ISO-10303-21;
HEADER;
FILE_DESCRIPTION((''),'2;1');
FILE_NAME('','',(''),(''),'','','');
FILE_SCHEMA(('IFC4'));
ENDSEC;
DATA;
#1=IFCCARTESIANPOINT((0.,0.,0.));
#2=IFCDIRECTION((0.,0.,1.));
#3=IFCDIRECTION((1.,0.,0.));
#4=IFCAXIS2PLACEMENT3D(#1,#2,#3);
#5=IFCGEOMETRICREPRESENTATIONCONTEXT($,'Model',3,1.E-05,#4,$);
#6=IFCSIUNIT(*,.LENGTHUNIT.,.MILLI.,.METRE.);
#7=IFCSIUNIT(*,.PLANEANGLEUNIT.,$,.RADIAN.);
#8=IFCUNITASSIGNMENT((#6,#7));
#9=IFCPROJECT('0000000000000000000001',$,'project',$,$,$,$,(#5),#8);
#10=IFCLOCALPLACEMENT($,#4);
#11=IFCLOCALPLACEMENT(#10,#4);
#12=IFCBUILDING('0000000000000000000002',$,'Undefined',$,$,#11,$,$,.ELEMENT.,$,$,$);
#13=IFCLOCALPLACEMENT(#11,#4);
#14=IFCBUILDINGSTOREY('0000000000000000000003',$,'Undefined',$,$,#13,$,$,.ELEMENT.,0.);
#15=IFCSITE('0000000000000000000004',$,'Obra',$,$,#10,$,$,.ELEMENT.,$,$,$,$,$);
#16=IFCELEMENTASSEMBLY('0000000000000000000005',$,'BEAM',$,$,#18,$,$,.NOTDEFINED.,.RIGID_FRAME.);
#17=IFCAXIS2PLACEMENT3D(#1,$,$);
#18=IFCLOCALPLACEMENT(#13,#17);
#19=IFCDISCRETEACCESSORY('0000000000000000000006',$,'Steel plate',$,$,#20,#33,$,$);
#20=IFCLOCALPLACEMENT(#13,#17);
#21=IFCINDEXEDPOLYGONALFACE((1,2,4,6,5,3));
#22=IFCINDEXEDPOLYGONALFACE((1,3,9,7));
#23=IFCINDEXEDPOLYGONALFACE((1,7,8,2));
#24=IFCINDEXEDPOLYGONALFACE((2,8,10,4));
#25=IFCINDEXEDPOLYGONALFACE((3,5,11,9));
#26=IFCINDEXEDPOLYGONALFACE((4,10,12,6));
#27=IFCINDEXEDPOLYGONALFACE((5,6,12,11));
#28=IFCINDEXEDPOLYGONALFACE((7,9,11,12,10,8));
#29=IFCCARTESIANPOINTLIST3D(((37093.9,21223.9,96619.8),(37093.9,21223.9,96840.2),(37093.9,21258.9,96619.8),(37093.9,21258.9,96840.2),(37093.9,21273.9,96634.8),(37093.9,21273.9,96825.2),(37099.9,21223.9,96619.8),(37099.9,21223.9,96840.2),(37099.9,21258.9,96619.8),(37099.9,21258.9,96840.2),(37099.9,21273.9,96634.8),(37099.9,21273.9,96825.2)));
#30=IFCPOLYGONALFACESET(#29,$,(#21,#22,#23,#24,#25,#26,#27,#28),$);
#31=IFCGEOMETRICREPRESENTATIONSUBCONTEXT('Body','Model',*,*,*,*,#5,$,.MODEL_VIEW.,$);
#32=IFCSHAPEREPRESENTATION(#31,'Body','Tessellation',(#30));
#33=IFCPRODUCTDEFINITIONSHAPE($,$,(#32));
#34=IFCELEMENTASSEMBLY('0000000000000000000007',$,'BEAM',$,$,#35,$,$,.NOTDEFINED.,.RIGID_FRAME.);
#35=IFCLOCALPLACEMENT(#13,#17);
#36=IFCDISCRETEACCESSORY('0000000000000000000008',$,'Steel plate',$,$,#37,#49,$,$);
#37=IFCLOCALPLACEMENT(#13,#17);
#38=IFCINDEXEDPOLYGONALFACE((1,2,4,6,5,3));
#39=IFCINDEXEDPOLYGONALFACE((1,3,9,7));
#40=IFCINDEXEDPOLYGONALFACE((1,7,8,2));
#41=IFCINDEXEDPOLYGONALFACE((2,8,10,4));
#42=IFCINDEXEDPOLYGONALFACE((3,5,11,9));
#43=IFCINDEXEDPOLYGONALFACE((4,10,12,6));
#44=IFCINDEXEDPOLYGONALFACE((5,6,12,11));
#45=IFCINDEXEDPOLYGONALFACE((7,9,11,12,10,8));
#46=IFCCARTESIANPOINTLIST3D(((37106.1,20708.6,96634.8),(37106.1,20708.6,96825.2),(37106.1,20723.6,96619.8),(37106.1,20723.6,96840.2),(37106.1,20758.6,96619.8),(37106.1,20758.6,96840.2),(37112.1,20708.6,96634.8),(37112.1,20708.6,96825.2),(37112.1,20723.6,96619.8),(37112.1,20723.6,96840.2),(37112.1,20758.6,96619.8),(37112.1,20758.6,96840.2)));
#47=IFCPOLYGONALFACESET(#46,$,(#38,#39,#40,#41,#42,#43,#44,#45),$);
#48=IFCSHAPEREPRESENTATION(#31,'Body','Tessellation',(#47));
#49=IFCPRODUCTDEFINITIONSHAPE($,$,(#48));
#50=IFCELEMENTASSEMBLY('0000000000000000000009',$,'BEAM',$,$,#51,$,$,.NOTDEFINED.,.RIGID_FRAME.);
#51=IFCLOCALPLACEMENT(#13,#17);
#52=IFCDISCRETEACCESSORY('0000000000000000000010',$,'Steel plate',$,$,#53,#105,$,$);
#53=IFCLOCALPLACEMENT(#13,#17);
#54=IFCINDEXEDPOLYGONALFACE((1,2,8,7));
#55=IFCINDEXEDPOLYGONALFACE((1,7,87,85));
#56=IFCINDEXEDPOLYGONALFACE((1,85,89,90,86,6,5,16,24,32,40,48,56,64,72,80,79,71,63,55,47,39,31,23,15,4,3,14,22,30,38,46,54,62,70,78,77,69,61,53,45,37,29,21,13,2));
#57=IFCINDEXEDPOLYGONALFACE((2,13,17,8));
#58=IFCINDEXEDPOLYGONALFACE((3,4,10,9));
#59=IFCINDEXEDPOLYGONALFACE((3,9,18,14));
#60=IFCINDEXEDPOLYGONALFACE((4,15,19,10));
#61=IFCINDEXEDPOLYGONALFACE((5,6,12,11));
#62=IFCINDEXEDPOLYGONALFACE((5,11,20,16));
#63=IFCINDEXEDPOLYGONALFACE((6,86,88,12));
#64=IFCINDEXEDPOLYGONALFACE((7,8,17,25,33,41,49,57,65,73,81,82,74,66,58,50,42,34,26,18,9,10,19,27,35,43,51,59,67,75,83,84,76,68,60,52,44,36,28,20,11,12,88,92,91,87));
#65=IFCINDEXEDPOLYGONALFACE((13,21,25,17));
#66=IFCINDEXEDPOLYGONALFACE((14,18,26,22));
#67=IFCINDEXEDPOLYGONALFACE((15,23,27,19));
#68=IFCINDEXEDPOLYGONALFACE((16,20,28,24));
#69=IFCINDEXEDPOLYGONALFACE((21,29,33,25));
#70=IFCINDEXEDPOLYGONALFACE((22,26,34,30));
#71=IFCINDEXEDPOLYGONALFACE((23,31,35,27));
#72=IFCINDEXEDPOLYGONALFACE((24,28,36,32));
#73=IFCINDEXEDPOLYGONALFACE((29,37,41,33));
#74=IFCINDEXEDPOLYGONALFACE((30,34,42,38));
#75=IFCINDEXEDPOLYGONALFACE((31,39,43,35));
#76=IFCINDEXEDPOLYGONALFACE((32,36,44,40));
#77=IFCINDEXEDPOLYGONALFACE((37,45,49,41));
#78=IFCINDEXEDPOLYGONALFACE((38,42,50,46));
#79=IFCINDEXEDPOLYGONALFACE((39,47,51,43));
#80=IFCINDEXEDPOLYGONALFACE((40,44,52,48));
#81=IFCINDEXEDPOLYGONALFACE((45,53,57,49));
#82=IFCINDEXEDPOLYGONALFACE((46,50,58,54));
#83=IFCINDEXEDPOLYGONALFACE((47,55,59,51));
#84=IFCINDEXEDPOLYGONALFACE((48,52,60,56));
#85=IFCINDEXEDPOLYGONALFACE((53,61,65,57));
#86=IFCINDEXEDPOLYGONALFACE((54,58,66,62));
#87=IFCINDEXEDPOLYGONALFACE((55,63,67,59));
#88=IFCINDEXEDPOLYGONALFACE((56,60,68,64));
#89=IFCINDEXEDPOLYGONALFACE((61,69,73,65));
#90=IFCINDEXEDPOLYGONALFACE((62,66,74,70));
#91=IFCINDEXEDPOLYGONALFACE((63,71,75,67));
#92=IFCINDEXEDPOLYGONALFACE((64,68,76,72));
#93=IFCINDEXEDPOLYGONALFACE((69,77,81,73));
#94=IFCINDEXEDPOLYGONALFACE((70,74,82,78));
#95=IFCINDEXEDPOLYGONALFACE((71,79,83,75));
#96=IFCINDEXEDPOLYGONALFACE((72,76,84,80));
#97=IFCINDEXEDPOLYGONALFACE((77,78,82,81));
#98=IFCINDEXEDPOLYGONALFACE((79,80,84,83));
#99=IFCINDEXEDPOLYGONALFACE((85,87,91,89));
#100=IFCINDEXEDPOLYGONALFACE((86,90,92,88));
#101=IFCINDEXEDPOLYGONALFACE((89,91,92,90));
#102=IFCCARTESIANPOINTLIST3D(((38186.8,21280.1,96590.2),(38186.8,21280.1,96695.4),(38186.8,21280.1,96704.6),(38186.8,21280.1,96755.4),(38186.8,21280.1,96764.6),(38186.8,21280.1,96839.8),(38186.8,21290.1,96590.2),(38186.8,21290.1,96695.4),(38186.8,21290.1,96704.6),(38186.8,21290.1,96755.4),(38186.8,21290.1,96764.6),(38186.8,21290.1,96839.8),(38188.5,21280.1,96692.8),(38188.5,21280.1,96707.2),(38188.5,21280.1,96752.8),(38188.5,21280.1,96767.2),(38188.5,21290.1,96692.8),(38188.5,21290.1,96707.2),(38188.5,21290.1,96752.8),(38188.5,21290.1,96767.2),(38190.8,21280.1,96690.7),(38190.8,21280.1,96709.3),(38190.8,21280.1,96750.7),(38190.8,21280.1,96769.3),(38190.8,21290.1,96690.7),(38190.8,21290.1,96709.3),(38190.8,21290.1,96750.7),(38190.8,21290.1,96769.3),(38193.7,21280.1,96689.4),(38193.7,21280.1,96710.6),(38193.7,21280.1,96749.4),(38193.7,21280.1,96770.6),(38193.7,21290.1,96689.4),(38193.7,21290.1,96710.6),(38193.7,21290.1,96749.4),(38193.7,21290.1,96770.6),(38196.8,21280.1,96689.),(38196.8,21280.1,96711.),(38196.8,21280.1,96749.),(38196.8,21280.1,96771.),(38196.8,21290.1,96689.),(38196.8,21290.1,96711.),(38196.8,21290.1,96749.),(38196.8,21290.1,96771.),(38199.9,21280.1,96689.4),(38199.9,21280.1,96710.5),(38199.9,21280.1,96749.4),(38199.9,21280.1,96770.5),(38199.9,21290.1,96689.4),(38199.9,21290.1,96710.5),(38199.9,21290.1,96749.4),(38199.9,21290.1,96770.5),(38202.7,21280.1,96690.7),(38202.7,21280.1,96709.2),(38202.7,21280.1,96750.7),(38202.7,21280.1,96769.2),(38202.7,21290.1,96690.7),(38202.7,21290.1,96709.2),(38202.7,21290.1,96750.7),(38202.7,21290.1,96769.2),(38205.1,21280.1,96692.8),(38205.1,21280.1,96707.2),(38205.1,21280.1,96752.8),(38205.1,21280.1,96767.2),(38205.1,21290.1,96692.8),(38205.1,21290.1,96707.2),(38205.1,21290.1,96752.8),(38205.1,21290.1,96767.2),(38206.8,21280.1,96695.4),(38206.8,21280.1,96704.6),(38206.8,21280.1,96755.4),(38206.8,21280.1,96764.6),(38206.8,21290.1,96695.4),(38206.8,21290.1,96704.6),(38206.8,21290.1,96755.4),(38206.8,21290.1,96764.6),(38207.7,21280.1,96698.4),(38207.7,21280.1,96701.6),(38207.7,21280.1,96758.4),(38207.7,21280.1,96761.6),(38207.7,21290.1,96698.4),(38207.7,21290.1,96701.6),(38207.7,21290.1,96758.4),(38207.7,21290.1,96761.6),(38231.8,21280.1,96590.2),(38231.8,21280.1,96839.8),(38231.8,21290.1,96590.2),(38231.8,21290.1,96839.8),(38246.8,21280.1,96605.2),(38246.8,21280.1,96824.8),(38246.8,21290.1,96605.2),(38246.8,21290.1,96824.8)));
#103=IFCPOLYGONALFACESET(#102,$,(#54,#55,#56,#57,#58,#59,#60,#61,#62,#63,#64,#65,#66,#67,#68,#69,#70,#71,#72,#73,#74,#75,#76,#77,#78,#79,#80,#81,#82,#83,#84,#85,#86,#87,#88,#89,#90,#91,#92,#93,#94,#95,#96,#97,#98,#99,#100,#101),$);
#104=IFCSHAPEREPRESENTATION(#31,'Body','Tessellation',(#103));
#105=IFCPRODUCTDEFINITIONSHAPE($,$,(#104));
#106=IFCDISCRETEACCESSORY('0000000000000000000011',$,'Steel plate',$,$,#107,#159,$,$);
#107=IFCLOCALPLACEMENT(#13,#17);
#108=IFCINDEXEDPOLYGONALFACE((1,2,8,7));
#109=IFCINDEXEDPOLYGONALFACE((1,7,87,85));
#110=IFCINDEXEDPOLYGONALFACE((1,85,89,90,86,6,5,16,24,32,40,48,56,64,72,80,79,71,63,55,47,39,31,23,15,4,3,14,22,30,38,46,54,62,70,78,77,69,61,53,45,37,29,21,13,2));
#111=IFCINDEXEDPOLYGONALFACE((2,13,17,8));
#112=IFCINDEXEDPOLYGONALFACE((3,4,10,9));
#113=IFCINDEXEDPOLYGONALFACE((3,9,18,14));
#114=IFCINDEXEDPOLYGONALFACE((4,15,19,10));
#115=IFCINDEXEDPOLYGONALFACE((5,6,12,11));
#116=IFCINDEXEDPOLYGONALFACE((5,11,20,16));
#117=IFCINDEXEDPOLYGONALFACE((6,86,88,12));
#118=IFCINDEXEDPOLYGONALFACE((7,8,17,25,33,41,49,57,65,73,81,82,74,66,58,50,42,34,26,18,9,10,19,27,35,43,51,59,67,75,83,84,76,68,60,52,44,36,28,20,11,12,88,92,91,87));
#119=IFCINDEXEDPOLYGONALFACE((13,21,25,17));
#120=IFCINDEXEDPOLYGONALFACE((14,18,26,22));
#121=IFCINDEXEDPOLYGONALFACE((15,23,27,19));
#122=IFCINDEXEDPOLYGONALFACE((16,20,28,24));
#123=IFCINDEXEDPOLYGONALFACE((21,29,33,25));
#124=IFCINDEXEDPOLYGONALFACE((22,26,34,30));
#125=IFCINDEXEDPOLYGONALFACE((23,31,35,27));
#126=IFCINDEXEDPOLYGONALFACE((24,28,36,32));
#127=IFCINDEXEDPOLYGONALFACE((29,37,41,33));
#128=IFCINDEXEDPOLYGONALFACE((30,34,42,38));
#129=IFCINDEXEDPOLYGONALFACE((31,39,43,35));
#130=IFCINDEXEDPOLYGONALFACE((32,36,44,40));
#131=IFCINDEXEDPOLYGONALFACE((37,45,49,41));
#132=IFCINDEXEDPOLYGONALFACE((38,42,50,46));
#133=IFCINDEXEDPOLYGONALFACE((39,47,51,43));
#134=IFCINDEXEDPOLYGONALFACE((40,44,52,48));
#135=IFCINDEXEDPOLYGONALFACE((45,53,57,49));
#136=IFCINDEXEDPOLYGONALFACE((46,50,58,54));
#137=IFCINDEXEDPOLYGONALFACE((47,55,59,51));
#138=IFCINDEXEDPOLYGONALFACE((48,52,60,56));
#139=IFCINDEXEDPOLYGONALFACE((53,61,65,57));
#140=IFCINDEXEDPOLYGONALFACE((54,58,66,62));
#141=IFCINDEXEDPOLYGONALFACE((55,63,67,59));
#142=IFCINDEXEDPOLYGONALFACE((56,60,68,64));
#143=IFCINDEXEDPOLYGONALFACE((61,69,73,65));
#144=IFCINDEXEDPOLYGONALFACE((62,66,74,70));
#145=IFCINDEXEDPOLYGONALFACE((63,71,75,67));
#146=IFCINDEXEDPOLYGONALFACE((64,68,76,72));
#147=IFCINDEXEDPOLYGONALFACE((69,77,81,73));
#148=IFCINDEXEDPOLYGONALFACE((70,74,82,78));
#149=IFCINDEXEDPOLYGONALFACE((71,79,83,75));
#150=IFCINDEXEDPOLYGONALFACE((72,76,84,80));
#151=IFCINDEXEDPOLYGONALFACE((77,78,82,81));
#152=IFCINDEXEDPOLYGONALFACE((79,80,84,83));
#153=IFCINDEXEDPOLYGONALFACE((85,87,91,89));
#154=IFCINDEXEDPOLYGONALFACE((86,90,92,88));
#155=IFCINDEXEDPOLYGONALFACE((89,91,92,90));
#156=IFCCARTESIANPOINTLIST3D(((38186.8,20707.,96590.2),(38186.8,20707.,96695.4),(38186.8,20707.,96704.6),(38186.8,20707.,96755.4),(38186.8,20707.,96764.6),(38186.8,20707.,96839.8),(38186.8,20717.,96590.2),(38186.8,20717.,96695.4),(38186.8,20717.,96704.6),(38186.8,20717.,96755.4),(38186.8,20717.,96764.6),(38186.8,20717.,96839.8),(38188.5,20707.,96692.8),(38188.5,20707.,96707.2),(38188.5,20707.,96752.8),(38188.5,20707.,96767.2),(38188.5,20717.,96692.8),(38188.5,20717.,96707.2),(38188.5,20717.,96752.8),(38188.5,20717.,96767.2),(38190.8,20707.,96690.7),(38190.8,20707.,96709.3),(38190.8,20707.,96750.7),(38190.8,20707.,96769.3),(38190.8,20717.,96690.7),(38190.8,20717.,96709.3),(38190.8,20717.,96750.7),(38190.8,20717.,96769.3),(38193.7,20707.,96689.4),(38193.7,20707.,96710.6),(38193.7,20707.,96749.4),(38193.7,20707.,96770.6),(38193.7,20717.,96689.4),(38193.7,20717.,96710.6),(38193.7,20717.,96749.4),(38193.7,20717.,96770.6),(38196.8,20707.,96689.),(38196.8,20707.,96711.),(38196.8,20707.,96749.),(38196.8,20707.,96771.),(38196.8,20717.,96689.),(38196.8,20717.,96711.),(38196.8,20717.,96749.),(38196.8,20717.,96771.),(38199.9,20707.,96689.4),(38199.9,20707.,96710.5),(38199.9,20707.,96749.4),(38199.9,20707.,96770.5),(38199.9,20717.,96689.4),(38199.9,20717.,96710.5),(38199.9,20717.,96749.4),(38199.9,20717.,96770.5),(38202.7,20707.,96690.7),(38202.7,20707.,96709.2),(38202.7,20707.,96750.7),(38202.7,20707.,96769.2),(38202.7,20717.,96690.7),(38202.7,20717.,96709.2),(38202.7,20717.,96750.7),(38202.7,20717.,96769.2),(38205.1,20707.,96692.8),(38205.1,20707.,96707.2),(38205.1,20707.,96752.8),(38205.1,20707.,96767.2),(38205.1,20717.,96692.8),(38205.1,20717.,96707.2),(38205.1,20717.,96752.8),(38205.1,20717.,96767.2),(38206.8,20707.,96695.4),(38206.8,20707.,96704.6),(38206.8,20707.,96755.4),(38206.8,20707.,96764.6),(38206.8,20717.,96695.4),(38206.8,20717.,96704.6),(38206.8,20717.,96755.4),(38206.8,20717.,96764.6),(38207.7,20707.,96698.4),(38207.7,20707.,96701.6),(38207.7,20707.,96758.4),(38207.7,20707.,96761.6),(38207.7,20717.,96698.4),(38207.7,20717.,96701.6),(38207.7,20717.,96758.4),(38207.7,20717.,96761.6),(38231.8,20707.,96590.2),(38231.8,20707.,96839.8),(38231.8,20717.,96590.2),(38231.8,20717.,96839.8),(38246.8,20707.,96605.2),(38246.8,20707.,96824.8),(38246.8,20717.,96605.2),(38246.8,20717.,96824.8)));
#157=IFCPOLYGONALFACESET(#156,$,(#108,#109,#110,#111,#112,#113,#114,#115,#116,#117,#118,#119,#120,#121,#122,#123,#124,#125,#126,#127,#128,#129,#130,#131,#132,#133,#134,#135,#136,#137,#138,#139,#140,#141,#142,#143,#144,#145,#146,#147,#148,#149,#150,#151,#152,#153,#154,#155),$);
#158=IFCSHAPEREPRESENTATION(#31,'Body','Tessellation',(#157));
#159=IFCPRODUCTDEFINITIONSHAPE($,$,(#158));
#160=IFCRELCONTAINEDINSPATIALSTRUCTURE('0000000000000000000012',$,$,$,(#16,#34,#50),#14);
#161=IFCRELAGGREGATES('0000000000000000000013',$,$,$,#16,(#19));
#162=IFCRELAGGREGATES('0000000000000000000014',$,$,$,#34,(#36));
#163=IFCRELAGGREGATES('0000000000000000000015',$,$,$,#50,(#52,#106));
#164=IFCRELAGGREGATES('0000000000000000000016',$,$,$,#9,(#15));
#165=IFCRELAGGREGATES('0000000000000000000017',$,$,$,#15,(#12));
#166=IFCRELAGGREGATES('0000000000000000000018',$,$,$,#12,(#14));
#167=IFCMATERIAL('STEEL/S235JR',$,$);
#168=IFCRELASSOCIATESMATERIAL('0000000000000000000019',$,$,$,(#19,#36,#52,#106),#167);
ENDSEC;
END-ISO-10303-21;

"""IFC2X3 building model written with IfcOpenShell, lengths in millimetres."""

from ifc_helpers import new_model, si_unit, frame, origin_with_axes, origin_2d_with_axis, place, context, subcontext, project, spatial, polyline, circle, outline, extrude, source, transform, mapped, material, element, aggregate, save


model = new_model("IFC2X3")

# Units and contexts
model_context = context("Model", 3, precision=1e-05, world=origin_with_axes())
body_context = subcontext(model_context, "Body", "Model", "MODEL_VIEW")
ifc_project = project(units=[si_unit("LENGTHUNIT", "METRE", prefix="MILLI"), si_unit("PLANEANGLEUNIT", "RADIAN")], contexts=[model_context])

# Site, building, storey
site_placement = place(None, origin_with_axes())
site = spatial("IfcSite", under=ifc_project, at=site_placement, Name="Obra", CompositionType="ELEMENT")
building_placement = place(site_placement, origin_with_axes())
building = spatial("IfcBuilding", under=site, at=building_placement, Name="Undefined", CompositionType="ELEMENT")
storey_placement = place(building_placement, origin_with_axes())
storey = spatial("IfcBuildingStorey", under=building, at=storey_placement, Name="Undefined", CompositionType="ELEMENT", Elevation=0.0)

# Element assemblies, discrete accessories
assembly_1_placement = place(storey_placement, origin_with_axes())
assembly_1 = element("IfcElementAssembly", 1, at=assembly_1_placement, inside=storey, Name="BEAM", AssemblyPlace="NOTDEFINED", PredefinedType="RIGID_FRAME")
ifc_material = material(Name="STEEL/S235JR")
discrete_accessory_1_placement = place(assembly_1_placement, frame((37096.9, 21223.9, 96619.8), z_axis=(1.0, 0.0, 0.0), x_axis=(0.0, 1.0, 0.0)))
discrete_accessory_1 = element("IfcDiscreteAccessory", 2, at=discrete_accessory_1_placement, material=ifc_material, Name="Steel plate", context=body_context, shape_type="SweptSolid", body=[
    extrude(outline(polyline([(0.0, 0.0), (35.0, 0.0), (50.0, 15.0), (50.0, 205.4), (35.0, 220.4), (0.0, 220.4), (0.0, 0.0)])), frame((0.0, 0.0, -3.0), z_axis=(0.0, 0.0, 1.0), x_axis=(1.0, 0.0, 0.0)), (0.0, 0.0, 1.0), 6.0),
])
aggregate(assembly_1, [discrete_accessory_1])
assembly_2_placement = place(storey_placement, origin_with_axes())
assembly_2 = element("IfcElementAssembly", 3, at=assembly_2_placement, inside=storey, Name="BEAM", AssemblyPlace="NOTDEFINED", PredefinedType="RIGID_FRAME")
discrete_accessory_2_placement = place(assembly_2_placement, frame((37109.1, 20758.6, 96619.8), z_axis=(-0.999999, 0.001435, 0.0), x_axis=(-0.001435, -0.999999, 0.0)))
discrete_accessory_2 = element("IfcDiscreteAccessory", 4, at=discrete_accessory_2_placement, material=ifc_material, Name="Steel plate", context=body_context, shape_type="SweptSolid", body=[
    extrude(outline(polyline([(0.0, 0.0), (35.0, 0.0), (50.0, 15.0), (50.0, 205.4), (35.0, 220.4), (0.0, 220.4), (0.0, 0.0)])), frame((0.0, 0.0, -3.0), z_axis=(0.0, 0.0, 1.0), x_axis=(1.0, 0.0, 0.0)), (0.0, 0.0, 1.0), 6.0),
])
aggregate(assembly_2, [discrete_accessory_2])

# Element assembly, discrete accessories, openings
assembly_3_placement = place(storey_placement, origin_with_axes())
assembly_3 = element("IfcElementAssembly", 5, at=assembly_3_placement, inside=storey, Name="BEAM", AssemblyPlace="NOTDEFINED", PredefinedType="RIGID_FRAME")
discrete_accessory_3_placement = place(assembly_3_placement, frame((38186.8, 21285.1, 96590.2), z_axis=(0.0, -1.0, 0.0), x_axis=(1.0, 0.0, 0.0)))
discrete_accessory_3 = element("IfcDiscreteAccessory", 6, at=discrete_accessory_3_placement, material=ifc_material, Name="Steel plate", context=body_context, shape_type="SweptSolid", body=[
    extrude(outline(polyline([(0.0, 0.0), (45.0, 0.0), (60.0, 15.0), (60.0, 234.6), (45.0, 249.6), (0.0, 249.6), (0.0, 0.0)])), frame((0.0, 0.0, -5.0), z_axis=(0.0, 0.0, 1.0), x_axis=(1.0, 0.0, 0.0)), (0.0, 0.0, 1.0), 10.0),
])
shared_shape_1 = source(origin_with_axes(), body_context, "Body", "SweptSolid", [
    extrude(circle(Radius=11.0, at=origin_2d_with_axis()), frame((0.0, -13.2, 0.0), z_axis=(0.0, 1.0, 0.0), x_axis=(1.0, 0.0, 0.0)), (0.0, 0.0, 1.0), 10.2),
])
opening_1_placement = place(assembly_3_placement, frame((38236.8, 21277.0, 96850.0), z_axis=(-1.0, 0.0, 0.0), x_axis=(0.0, 0.0, -1.0)))
element("IfcOpeningElement", 7, at=opening_1_placement, cuts=discrete_accessory_3, ObjectType="Opening", context=body_context, shape_type="MappedRepresentation", body=[
    mapped(shared_shape_1, transform((90.0, 0.0, 40.0))),
    mapped(shared_shape_1, transform((150.0, 0.0, 40.0))),
])
discrete_accessory_4_placement = place(assembly_3_placement, frame((38186.8, 20712.0, 96590.2), z_axis=(0.0, -1.0, 0.0), x_axis=(1.0, 0.0, 0.0)))
discrete_accessory_4 = element("IfcDiscreteAccessory", 8, at=discrete_accessory_4_placement, material=ifc_material, Name="Steel plate", context=body_context, shape_type="SweptSolid", body=[
    extrude(outline(polyline([(0.0, 0.0), (45.0, 0.0), (60.0, 15.0), (60.0, 234.6), (45.0, 249.6), (0.0, 249.6), (0.0, 0.0)])), frame((0.0, 0.0, -5.0), z_axis=(0.0, 0.0, 1.0), x_axis=(1.0, 0.0, 0.0)), (0.0, 0.0, 1.0), 10.0),
])
opening_2_placement = place(assembly_3_placement, frame((38236.8, 20703.9, 96850.0), z_axis=(-1.0, 0.0, 0.0), x_axis=(0.0, 0.0, -1.0)))
element("IfcOpeningElement", 9, at=opening_2_placement, cuts=discrete_accessory_4, ObjectType="Opening", context=body_context, shape_type="MappedRepresentation", body=[
    mapped(shared_shape_1, transform((90.0, 0.0, 40.0))),
    mapped(shared_shape_1, transform((150.0, 0.0, 40.0))),
])

aggregate(assembly_3, [discrete_accessory_3, discrete_accessory_4])

save(model, "model.ifc")
